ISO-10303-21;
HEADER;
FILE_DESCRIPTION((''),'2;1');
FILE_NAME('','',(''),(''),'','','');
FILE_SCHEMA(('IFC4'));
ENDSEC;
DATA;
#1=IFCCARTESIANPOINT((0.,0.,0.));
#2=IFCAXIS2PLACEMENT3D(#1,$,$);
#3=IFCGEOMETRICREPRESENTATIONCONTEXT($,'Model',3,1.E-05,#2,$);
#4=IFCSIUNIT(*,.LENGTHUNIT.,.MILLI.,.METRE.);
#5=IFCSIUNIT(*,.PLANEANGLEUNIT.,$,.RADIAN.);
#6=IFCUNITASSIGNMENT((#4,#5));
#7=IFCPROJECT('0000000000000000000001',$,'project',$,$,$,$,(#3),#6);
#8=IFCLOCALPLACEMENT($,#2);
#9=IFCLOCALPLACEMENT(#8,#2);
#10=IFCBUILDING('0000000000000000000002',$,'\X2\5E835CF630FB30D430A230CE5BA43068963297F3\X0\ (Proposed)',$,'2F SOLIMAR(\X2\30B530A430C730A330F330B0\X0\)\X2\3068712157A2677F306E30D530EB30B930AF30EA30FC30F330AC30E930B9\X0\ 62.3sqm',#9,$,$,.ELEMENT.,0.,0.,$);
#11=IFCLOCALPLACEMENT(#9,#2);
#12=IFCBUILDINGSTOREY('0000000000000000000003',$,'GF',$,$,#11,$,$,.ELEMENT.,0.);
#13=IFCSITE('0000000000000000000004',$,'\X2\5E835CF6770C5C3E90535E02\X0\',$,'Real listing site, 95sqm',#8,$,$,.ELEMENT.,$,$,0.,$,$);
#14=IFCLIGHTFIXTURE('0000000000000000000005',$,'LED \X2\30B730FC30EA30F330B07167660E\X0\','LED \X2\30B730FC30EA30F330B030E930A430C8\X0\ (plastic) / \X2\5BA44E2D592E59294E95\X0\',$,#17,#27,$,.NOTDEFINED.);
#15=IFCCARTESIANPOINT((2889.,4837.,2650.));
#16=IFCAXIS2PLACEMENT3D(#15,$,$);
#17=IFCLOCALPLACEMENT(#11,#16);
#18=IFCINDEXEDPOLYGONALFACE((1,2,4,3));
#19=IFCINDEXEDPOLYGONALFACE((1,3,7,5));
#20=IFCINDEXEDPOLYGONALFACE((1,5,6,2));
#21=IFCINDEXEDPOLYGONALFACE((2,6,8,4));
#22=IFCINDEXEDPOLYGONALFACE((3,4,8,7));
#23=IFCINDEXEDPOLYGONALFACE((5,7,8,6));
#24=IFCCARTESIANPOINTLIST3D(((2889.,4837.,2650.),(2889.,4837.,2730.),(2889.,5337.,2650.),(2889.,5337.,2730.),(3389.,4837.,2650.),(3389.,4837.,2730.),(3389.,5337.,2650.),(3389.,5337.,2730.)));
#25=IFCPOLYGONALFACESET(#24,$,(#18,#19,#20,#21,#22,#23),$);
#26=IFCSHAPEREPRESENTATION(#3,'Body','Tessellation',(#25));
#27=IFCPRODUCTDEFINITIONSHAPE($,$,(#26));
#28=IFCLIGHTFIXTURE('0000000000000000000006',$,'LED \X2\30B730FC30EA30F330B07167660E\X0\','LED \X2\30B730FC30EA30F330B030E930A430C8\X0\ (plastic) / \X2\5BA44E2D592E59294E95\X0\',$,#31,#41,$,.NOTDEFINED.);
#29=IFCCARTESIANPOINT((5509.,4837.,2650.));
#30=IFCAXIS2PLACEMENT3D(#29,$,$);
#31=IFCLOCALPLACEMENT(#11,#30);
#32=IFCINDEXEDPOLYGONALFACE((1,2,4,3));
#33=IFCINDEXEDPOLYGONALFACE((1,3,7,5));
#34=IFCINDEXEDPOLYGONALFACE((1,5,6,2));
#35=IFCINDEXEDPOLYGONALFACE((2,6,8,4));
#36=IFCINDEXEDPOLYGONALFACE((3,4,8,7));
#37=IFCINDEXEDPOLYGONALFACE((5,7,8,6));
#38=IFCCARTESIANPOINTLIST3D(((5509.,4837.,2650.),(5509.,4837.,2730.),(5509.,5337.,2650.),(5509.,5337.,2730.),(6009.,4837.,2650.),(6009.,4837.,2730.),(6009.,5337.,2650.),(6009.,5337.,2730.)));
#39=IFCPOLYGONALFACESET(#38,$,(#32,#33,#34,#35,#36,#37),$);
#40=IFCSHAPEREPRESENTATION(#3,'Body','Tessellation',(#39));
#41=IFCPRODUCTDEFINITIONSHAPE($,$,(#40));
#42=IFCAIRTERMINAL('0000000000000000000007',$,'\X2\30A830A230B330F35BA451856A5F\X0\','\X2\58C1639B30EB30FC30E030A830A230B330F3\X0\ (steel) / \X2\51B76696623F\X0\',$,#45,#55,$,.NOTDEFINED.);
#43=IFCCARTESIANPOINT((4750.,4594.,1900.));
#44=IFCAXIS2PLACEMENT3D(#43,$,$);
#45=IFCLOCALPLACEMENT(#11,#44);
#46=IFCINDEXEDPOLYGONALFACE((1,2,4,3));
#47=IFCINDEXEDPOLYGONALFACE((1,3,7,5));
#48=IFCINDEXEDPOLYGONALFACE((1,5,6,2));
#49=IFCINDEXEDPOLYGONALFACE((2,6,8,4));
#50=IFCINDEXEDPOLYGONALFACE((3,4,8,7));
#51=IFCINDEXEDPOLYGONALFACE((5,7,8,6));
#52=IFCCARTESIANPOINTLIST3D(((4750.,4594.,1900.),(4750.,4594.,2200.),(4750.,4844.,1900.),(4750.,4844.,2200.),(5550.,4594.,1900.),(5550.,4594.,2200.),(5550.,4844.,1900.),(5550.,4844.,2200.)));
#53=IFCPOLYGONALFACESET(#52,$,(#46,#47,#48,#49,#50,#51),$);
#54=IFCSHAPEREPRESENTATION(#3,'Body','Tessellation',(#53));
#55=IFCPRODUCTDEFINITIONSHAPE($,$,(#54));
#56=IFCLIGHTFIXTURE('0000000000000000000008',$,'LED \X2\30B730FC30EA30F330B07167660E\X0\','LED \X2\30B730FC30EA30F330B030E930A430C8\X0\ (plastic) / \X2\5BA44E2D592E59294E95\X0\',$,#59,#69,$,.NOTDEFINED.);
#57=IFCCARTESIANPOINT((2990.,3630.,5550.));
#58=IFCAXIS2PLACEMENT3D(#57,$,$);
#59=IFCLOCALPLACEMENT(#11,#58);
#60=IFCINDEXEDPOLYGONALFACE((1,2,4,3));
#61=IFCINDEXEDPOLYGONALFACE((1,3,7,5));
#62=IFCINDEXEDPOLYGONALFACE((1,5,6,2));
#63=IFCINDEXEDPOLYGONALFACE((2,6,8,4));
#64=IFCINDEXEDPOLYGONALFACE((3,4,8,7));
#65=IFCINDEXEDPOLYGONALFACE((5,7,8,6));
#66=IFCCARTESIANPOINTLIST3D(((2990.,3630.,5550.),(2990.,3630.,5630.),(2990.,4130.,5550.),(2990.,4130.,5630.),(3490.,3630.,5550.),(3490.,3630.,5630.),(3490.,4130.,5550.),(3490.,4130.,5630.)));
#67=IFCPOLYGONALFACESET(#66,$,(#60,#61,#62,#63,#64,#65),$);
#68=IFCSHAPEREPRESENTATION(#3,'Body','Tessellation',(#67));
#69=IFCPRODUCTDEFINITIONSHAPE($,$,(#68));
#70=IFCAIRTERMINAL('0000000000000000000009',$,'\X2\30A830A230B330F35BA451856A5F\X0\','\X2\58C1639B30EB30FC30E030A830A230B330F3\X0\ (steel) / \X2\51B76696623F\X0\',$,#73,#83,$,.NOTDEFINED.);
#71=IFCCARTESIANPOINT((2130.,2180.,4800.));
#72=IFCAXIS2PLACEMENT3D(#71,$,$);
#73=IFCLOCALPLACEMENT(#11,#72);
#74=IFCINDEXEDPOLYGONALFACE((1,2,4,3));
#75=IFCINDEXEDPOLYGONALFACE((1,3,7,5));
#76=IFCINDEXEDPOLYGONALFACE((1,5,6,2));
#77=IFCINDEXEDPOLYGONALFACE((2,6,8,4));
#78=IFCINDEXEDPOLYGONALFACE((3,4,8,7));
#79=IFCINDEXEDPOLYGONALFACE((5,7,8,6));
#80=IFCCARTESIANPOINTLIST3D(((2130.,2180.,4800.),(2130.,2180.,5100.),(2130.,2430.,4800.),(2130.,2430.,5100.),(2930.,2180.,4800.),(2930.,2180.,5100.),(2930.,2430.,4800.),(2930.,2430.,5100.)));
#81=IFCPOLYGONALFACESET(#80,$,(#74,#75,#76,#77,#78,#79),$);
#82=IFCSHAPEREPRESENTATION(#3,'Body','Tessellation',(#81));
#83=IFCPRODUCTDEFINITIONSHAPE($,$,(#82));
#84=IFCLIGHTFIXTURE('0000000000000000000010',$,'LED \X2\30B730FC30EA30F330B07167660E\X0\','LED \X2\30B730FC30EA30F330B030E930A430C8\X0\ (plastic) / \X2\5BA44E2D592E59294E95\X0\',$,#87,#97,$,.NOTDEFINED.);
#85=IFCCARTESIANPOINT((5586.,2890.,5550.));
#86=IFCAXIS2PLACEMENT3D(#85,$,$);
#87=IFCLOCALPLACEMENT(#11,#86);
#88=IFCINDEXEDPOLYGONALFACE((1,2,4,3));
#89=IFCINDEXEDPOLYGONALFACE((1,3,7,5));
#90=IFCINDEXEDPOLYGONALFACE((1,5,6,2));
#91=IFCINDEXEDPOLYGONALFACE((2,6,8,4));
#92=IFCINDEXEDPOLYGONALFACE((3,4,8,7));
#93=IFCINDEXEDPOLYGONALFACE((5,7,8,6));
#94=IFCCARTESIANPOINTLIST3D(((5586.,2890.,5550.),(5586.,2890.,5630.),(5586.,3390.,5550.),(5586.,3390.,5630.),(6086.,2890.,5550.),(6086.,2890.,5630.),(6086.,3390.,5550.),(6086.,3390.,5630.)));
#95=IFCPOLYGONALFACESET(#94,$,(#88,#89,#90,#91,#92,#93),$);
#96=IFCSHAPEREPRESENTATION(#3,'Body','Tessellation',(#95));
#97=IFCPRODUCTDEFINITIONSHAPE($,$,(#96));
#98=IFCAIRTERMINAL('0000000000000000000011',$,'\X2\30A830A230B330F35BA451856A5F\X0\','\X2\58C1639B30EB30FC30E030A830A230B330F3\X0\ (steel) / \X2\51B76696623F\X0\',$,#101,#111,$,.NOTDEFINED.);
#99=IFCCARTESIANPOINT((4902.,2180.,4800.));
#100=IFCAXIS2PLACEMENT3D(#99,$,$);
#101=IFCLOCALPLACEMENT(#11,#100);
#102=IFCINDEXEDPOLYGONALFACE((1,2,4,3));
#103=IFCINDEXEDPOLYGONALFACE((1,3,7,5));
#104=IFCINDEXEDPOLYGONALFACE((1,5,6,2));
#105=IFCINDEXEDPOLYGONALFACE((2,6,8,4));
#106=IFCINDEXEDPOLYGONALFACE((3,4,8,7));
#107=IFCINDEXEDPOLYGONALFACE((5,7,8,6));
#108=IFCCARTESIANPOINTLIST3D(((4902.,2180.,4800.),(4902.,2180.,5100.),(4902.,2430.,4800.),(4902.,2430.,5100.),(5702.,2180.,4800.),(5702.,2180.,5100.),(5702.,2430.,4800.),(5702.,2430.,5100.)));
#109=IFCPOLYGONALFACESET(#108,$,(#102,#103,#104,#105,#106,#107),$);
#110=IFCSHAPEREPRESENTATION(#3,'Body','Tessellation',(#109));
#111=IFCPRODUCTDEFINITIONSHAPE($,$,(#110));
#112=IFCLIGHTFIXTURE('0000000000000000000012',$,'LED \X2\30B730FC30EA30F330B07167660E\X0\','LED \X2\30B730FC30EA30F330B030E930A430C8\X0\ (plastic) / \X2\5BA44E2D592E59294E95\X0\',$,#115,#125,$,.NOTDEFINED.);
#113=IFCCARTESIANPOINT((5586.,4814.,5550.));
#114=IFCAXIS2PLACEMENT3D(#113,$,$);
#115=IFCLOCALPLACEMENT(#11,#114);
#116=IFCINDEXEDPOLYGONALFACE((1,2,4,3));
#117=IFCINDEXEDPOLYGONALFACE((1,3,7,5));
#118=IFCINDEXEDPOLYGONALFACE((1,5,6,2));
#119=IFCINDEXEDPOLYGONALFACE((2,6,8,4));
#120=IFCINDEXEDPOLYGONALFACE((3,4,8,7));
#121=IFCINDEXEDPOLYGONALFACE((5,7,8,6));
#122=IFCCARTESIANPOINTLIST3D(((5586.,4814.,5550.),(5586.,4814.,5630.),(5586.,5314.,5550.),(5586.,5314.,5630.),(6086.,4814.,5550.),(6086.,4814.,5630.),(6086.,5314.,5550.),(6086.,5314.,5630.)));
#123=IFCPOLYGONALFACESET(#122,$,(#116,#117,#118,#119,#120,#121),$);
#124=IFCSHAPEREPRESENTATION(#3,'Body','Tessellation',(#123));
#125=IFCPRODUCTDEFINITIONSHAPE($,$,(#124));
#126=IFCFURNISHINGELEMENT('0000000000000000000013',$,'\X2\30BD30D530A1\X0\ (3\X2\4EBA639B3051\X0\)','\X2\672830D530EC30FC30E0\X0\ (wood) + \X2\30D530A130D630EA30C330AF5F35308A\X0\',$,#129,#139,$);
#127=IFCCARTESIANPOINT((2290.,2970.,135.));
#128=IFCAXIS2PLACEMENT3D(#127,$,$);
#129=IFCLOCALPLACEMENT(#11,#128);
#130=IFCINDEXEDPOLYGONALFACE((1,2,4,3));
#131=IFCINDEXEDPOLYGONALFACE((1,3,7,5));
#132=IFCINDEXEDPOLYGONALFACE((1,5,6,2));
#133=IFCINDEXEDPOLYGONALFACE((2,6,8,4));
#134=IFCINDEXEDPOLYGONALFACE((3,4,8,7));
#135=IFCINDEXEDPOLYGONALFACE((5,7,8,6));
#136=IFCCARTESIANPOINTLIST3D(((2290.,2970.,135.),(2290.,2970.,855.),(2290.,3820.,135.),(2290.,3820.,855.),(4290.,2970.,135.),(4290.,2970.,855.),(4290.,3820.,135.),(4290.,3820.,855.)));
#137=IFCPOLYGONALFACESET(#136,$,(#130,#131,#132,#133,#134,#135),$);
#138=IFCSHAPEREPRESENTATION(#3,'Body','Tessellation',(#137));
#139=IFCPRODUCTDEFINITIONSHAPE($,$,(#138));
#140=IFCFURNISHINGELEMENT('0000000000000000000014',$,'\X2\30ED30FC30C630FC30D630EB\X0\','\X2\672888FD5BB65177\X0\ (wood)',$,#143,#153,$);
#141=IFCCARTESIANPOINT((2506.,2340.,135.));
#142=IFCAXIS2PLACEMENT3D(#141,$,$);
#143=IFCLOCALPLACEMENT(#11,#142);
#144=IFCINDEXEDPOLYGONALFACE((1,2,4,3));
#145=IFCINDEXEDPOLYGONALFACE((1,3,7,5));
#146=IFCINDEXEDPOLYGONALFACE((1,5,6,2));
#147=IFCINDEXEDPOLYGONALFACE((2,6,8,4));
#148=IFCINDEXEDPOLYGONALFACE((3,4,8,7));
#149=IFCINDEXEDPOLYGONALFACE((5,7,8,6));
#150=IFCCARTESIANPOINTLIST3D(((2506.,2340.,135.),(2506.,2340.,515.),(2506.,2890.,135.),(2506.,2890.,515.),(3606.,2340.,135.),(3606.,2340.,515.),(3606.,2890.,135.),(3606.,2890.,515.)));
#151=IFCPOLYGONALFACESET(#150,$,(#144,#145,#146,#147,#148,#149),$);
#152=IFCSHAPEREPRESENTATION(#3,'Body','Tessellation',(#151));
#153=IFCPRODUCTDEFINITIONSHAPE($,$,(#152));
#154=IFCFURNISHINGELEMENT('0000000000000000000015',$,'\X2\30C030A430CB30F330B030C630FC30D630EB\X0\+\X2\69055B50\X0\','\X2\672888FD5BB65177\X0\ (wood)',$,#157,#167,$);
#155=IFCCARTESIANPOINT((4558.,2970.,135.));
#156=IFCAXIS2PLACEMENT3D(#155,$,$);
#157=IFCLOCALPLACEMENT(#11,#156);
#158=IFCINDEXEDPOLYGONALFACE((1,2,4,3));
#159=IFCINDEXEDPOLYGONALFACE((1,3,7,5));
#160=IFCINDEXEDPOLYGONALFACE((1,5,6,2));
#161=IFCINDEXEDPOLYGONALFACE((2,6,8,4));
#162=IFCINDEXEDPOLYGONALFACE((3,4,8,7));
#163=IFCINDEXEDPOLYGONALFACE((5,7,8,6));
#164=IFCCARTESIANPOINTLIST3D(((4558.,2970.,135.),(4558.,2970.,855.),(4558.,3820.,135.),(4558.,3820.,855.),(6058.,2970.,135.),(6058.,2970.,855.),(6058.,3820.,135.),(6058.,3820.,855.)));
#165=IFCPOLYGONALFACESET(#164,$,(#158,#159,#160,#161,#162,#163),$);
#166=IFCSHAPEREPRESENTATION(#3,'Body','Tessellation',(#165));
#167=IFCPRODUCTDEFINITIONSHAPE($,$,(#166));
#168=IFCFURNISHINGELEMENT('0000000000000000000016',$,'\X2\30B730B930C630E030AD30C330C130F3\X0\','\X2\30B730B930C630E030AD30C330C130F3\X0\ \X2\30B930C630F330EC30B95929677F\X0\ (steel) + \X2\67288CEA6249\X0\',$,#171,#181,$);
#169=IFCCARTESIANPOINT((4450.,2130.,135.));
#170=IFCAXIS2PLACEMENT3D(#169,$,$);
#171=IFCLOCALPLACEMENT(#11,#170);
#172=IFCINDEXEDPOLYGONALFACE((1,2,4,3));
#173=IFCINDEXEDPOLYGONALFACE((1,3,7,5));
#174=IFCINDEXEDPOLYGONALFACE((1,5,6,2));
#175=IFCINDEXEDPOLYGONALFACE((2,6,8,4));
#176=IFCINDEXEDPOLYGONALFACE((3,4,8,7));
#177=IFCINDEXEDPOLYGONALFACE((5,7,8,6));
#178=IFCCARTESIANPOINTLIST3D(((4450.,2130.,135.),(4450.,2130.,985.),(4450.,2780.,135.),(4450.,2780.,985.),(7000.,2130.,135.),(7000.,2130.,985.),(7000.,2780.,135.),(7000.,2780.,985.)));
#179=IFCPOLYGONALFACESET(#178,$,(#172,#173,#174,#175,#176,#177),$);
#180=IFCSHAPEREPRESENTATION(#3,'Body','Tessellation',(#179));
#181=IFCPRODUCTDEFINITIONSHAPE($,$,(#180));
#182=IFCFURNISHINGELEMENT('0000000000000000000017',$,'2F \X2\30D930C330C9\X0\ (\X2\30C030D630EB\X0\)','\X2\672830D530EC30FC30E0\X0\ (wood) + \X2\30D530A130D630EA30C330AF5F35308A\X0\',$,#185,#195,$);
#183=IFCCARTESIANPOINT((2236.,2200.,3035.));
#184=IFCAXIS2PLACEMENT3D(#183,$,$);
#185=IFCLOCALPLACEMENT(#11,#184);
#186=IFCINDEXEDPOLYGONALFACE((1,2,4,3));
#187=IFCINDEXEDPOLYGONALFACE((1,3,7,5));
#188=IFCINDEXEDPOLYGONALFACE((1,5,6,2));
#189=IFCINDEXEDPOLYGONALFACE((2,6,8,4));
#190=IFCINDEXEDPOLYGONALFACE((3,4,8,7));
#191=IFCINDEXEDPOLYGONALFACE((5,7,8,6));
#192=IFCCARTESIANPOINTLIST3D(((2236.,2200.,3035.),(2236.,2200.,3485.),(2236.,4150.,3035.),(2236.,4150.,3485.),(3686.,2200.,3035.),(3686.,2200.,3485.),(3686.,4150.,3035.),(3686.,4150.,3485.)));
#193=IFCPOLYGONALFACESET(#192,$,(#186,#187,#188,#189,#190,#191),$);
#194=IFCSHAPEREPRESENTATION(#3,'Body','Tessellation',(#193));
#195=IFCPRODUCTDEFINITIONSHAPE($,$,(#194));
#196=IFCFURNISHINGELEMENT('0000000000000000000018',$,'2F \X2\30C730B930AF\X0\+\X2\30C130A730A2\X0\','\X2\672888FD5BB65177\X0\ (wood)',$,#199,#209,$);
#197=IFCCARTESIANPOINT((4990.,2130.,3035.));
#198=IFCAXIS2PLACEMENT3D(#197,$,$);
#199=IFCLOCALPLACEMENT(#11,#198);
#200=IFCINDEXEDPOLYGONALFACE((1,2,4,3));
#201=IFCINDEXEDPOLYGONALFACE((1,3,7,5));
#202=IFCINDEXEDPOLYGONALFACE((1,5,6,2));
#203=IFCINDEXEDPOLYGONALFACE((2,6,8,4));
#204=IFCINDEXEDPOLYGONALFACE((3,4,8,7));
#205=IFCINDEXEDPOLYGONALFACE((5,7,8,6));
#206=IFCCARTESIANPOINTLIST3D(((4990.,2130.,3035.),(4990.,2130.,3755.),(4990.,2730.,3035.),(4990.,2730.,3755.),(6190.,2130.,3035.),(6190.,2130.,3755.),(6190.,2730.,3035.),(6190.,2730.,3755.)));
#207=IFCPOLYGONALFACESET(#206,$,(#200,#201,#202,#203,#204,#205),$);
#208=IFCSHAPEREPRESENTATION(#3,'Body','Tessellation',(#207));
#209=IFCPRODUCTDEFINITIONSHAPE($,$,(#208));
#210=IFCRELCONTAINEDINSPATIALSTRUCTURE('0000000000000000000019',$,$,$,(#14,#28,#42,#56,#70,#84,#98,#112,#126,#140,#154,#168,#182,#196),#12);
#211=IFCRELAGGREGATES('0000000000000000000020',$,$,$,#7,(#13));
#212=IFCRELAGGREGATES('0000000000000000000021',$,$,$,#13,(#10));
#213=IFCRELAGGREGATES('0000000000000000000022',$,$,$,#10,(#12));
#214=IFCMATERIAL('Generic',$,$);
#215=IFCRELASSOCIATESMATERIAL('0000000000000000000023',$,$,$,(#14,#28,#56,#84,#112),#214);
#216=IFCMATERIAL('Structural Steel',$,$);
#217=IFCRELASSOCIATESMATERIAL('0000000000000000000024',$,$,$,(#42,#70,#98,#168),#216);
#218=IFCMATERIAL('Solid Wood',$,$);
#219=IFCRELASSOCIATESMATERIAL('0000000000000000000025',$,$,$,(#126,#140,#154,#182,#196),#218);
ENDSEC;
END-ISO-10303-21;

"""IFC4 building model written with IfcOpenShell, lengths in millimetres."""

from ifc_helpers import new_model, si_unit, frame, frame_2d, origin, place, context, project, spatial, rectangle, extrude, material, element, save


model = new_model("IFC4")

# Units and contexts
model_context = context("Model", 3, precision=1e-05, world=origin())
ifc_project = project(units=[si_unit("LENGTHUNIT", "METRE", prefix="MILLI"), si_unit("PLANEANGLEUNIT", "RADIAN")], contexts=[model_context])

# Site, building, storey
site_placement = place(None, origin())
site = spatial("IfcSite", under=ifc_project, at=site_placement, Name="広島県尾道市", ObjectType="Real listing site, 95sqm", CompositionType="ELEMENT", RefElevation=0.0)
building_placement = place(site_placement, origin())
building = spatial("IfcBuilding", under=site, at=building_placement, Name="広島・ピアノ室と防音 (Proposed)", ObjectType="2F SOLIMAR(サイディング)と無垢板のフルスクリーンガラス 62.3sqm", CompositionType="ELEMENT", ElevationOfRefHeight=0.0, ElevationOfTerrain=0.0)
storey_placement = place(building_placement, origin())
storey = spatial("IfcBuildingStorey", under=building, at=storey_placement, Name="GF", CompositionType="ELEMENT", Elevation=0.0)

# Shared definitions
ifc_material_1 = material(Name="Solid Wood")

# Shared definitions
ifc_material_2 = material(Name="Structural Steel")

# Shared definitions
ifc_material_3 = material(Name="Generic")

# Light fixtures
light_fixture_1_placement = place(storey_placement, frame((2889.0, 4837.0, 2650.0)))
element("IfcLightFixture", 1, at=light_fixture_1_placement, inside=storey, material=ifc_material_3, Name="LED シーリング照明", Description="LED シーリングライト (plastic) / 室中央天井", PredefinedType="NOTDEFINED", context=model_context, shape_type="SweptSolid", body=[
    extrude(rectangle(XDim=500.0, YDim=500.0, at=frame_2d((250.0, 250.0))), frame((2889.0, 4837.0, 2650.0)), (0.0, 0.0, 1.0), 80.0),
])
light_fixture_2_placement = place(storey_placement, frame((5509.0, 4837.0, 2650.0)))
element("IfcLightFixture", 2, at=light_fixture_2_placement, inside=storey, material=ifc_material_3, Name="LED シーリング照明", Description="LED シーリングライト (plastic) / 室中央天井", PredefinedType="NOTDEFINED", context=model_context, shape_type="SweptSolid", body=[
    extrude(rectangle(XDim=500.0, YDim=500.0, at=frame_2d((250.0, 250.0))), frame((5509.0, 4837.0, 2650.0)), (0.0, 0.0, 1.0), 80.0),
])

# Air terminal
air_terminal_1_placement = place(storey_placement, frame((4750.0, 4594.0, 1900.0)))
element("IfcAirTerminal", 3, at=air_terminal_1_placement, inside=storey, material=ifc_material_2, Name="エアコン室内機", Description="壁掛ルームエアコン (steel) / 冷暖房", PredefinedType="NOTDEFINED", context=model_context, shape_type="SweptSolid", body=[
    extrude(rectangle(XDim=800.0, YDim=250.0, at=frame_2d((400.0, 125.0))), frame((4750.0, 4594.0, 1900.0)), (0.0, 0.0, 1.0), 300.0),
])

# Light fixture
light_fixture_3_placement = place(storey_placement, frame((2990.0, 3630.0, 5550.0)))
element("IfcLightFixture", 4, at=light_fixture_3_placement, inside=storey, material=ifc_material_3, Name="LED シーリング照明", Description="LED シーリングライト (plastic) / 室中央天井", PredefinedType="NOTDEFINED", context=model_context, shape_type="SweptSolid", body=[
    extrude(rectangle(XDim=500.0, YDim=500.0, at=frame_2d((250.0, 250.0))), frame((2990.0, 3630.0, 5550.0)), (0.0, 0.0, 1.0), 80.0),
])

# Air terminal
air_terminal_2_placement = place(storey_placement, frame((2130.0, 2180.0, 4800.0)))
element("IfcAirTerminal", 5, at=air_terminal_2_placement, inside=storey, material=ifc_material_2, Name="エアコン室内機", Description="壁掛ルームエアコン (steel) / 冷暖房", PredefinedType="NOTDEFINED", context=model_context, shape_type="SweptSolid", body=[
    extrude(rectangle(XDim=800.0, YDim=250.0, at=frame_2d((400.0, 125.0))), frame((2130.0, 2180.0, 4800.0)), (0.0, 0.0, 1.0), 300.0),
])

# Light fixture
light_fixture_4_placement = place(storey_placement, frame((5586.0, 2890.0, 5550.0)))
element("IfcLightFixture", 6, at=light_fixture_4_placement, inside=storey, material=ifc_material_3, Name="LED シーリング照明", Description="LED シーリングライト (plastic) / 室中央天井", PredefinedType="NOTDEFINED", context=model_context, shape_type="SweptSolid", body=[
    extrude(rectangle(XDim=500.0, YDim=500.0, at=frame_2d((250.0, 250.0))), frame((5586.0, 2890.0, 5550.0)), (0.0, 0.0, 1.0), 80.0),
])

# Air terminal
air_terminal_3_placement = place(storey_placement, frame((4902.0, 2180.0, 4800.0)))
element("IfcAirTerminal", 7, at=air_terminal_3_placement, inside=storey, material=ifc_material_2, Name="エアコン室内機", Description="壁掛ルームエアコン (steel) / 冷暖房", PredefinedType="NOTDEFINED", context=model_context, shape_type="SweptSolid", body=[
    extrude(rectangle(XDim=800.0, YDim=250.0, at=frame_2d((400.0, 125.0))), frame((4902.0, 2180.0, 4800.0)), (0.0, 0.0, 1.0), 300.0),
])

# Light fixture
light_fixture_5_placement = place(storey_placement, frame((5586.0, 4814.0, 5550.0)))
element("IfcLightFixture", 8, at=light_fixture_5_placement, inside=storey, material=ifc_material_3, Name="LED シーリング照明", Description="LED シーリングライト (plastic) / 室中央天井", PredefinedType="NOTDEFINED", context=model_context, shape_type="SweptSolid", body=[
    extrude(rectangle(XDim=500.0, YDim=500.0, at=frame_2d((250.0, 250.0))), frame((5586.0, 4814.0, 5550.0)), (0.0, 0.0, 1.0), 80.0),
])

# Furnishing elements
furnishing_1_placement = place(storey_placement, frame((2290.0, 2970.0, 135.0)))
element("IfcFurnishingElement", 9, at=furnishing_1_placement, inside=storey, material=ifc_material_1, Name="ソファ (3人掛け)", Description="木フレーム (wood) + ファブリック張り", context=model_context, shape_type="SweptSolid", body=[
    extrude(rectangle(XDim=2000.0, YDim=850.0, at=frame_2d((1000.0, 425.0))), frame((2290.0, 2970.0, 135.0)), (0.0, 0.0, 1.0), 720.0),
])
furnishing_2_placement = place(storey_placement, frame((2506.0, 2340.0, 135.0)))
element("IfcFurnishingElement", 10, at=furnishing_2_placement, inside=storey, material=ifc_material_1, Name="ローテーブル", Description="木製家具 (wood)", context=model_context, shape_type="SweptSolid", body=[
    extrude(rectangle(XDim=1100.0, YDim=550.0, at=frame_2d((550.0, 275.0))), frame((2506.0, 2340.0, 135.0)), (0.0, 0.0, 1.0), 380.0),
])
furnishing_3_placement = place(storey_placement, frame((4558.0, 2970.0, 135.0)))
element("IfcFurnishingElement", 11, at=furnishing_3_placement, inside=storey, material=ifc_material_1, Name="ダイニングテーブル+椅子", Description="木製家具 (wood)", context=model_context, shape_type="SweptSolid", body=[
    extrude(rectangle(XDim=1500.0, YDim=850.0, at=frame_2d((750.0, 425.0))), frame((4558.0, 2970.0, 135.0)), (0.0, 0.0, 1.0), 720.0),
])
furnishing_4_placement = place(storey_placement, frame((4450.0, 2130.0, 135.0)))
element("IfcFurnishingElement", 12, at=furnishing_4_placement, inside=storey, material=ifc_material_2, Name="システムキッチン", Description="システムキッチン ステンレス天板 (steel) + 木質扉", context=model_context, shape_type="SweptSolid", body=[
    extrude(rectangle(XDim=2550.0, YDim=650.0, at=frame_2d((1275.0, 325.0))), frame((4450.0, 2130.0, 135.0)), (0.0, 0.0, 1.0), 850.0),
])
furnishing_5_placement = place(storey_placement, frame((2236.0, 2200.0, 3035.0)))
element("IfcFurnishingElement", 13, at=furnishing_5_placement, inside=storey, material=ifc_material_1, Name="2F ベッド (ダブル)", Description="木フレーム (wood) + ファブリック張り", context=model_context, shape_type="SweptSolid", body=[
    extrude(rectangle(XDim=1450.0, YDim=1950.0, at=frame_2d((725.0, 975.0))), frame((2236.0, 2200.0, 3035.0)), (0.0, 0.0, 1.0), 450.0),
])
furnishing_6_placement = place(storey_placement, frame((4990.0, 2130.0, 3035.0)))
element("IfcFurnishingElement", 14, at=furnishing_6_placement, inside=storey, material=ifc_material_1, Name="2F デスク+チェア", Description="木製家具 (wood)", context=model_context, shape_type="SweptSolid", body=[
    extrude(rectangle(XDim=1200.0, YDim=600.0, at=frame_2d((600.0, 300.0))), frame((4990.0, 2130.0, 3035.0)), (0.0, 0.0, 1.0), 720.0),
])

save(model, "model.ifc")
